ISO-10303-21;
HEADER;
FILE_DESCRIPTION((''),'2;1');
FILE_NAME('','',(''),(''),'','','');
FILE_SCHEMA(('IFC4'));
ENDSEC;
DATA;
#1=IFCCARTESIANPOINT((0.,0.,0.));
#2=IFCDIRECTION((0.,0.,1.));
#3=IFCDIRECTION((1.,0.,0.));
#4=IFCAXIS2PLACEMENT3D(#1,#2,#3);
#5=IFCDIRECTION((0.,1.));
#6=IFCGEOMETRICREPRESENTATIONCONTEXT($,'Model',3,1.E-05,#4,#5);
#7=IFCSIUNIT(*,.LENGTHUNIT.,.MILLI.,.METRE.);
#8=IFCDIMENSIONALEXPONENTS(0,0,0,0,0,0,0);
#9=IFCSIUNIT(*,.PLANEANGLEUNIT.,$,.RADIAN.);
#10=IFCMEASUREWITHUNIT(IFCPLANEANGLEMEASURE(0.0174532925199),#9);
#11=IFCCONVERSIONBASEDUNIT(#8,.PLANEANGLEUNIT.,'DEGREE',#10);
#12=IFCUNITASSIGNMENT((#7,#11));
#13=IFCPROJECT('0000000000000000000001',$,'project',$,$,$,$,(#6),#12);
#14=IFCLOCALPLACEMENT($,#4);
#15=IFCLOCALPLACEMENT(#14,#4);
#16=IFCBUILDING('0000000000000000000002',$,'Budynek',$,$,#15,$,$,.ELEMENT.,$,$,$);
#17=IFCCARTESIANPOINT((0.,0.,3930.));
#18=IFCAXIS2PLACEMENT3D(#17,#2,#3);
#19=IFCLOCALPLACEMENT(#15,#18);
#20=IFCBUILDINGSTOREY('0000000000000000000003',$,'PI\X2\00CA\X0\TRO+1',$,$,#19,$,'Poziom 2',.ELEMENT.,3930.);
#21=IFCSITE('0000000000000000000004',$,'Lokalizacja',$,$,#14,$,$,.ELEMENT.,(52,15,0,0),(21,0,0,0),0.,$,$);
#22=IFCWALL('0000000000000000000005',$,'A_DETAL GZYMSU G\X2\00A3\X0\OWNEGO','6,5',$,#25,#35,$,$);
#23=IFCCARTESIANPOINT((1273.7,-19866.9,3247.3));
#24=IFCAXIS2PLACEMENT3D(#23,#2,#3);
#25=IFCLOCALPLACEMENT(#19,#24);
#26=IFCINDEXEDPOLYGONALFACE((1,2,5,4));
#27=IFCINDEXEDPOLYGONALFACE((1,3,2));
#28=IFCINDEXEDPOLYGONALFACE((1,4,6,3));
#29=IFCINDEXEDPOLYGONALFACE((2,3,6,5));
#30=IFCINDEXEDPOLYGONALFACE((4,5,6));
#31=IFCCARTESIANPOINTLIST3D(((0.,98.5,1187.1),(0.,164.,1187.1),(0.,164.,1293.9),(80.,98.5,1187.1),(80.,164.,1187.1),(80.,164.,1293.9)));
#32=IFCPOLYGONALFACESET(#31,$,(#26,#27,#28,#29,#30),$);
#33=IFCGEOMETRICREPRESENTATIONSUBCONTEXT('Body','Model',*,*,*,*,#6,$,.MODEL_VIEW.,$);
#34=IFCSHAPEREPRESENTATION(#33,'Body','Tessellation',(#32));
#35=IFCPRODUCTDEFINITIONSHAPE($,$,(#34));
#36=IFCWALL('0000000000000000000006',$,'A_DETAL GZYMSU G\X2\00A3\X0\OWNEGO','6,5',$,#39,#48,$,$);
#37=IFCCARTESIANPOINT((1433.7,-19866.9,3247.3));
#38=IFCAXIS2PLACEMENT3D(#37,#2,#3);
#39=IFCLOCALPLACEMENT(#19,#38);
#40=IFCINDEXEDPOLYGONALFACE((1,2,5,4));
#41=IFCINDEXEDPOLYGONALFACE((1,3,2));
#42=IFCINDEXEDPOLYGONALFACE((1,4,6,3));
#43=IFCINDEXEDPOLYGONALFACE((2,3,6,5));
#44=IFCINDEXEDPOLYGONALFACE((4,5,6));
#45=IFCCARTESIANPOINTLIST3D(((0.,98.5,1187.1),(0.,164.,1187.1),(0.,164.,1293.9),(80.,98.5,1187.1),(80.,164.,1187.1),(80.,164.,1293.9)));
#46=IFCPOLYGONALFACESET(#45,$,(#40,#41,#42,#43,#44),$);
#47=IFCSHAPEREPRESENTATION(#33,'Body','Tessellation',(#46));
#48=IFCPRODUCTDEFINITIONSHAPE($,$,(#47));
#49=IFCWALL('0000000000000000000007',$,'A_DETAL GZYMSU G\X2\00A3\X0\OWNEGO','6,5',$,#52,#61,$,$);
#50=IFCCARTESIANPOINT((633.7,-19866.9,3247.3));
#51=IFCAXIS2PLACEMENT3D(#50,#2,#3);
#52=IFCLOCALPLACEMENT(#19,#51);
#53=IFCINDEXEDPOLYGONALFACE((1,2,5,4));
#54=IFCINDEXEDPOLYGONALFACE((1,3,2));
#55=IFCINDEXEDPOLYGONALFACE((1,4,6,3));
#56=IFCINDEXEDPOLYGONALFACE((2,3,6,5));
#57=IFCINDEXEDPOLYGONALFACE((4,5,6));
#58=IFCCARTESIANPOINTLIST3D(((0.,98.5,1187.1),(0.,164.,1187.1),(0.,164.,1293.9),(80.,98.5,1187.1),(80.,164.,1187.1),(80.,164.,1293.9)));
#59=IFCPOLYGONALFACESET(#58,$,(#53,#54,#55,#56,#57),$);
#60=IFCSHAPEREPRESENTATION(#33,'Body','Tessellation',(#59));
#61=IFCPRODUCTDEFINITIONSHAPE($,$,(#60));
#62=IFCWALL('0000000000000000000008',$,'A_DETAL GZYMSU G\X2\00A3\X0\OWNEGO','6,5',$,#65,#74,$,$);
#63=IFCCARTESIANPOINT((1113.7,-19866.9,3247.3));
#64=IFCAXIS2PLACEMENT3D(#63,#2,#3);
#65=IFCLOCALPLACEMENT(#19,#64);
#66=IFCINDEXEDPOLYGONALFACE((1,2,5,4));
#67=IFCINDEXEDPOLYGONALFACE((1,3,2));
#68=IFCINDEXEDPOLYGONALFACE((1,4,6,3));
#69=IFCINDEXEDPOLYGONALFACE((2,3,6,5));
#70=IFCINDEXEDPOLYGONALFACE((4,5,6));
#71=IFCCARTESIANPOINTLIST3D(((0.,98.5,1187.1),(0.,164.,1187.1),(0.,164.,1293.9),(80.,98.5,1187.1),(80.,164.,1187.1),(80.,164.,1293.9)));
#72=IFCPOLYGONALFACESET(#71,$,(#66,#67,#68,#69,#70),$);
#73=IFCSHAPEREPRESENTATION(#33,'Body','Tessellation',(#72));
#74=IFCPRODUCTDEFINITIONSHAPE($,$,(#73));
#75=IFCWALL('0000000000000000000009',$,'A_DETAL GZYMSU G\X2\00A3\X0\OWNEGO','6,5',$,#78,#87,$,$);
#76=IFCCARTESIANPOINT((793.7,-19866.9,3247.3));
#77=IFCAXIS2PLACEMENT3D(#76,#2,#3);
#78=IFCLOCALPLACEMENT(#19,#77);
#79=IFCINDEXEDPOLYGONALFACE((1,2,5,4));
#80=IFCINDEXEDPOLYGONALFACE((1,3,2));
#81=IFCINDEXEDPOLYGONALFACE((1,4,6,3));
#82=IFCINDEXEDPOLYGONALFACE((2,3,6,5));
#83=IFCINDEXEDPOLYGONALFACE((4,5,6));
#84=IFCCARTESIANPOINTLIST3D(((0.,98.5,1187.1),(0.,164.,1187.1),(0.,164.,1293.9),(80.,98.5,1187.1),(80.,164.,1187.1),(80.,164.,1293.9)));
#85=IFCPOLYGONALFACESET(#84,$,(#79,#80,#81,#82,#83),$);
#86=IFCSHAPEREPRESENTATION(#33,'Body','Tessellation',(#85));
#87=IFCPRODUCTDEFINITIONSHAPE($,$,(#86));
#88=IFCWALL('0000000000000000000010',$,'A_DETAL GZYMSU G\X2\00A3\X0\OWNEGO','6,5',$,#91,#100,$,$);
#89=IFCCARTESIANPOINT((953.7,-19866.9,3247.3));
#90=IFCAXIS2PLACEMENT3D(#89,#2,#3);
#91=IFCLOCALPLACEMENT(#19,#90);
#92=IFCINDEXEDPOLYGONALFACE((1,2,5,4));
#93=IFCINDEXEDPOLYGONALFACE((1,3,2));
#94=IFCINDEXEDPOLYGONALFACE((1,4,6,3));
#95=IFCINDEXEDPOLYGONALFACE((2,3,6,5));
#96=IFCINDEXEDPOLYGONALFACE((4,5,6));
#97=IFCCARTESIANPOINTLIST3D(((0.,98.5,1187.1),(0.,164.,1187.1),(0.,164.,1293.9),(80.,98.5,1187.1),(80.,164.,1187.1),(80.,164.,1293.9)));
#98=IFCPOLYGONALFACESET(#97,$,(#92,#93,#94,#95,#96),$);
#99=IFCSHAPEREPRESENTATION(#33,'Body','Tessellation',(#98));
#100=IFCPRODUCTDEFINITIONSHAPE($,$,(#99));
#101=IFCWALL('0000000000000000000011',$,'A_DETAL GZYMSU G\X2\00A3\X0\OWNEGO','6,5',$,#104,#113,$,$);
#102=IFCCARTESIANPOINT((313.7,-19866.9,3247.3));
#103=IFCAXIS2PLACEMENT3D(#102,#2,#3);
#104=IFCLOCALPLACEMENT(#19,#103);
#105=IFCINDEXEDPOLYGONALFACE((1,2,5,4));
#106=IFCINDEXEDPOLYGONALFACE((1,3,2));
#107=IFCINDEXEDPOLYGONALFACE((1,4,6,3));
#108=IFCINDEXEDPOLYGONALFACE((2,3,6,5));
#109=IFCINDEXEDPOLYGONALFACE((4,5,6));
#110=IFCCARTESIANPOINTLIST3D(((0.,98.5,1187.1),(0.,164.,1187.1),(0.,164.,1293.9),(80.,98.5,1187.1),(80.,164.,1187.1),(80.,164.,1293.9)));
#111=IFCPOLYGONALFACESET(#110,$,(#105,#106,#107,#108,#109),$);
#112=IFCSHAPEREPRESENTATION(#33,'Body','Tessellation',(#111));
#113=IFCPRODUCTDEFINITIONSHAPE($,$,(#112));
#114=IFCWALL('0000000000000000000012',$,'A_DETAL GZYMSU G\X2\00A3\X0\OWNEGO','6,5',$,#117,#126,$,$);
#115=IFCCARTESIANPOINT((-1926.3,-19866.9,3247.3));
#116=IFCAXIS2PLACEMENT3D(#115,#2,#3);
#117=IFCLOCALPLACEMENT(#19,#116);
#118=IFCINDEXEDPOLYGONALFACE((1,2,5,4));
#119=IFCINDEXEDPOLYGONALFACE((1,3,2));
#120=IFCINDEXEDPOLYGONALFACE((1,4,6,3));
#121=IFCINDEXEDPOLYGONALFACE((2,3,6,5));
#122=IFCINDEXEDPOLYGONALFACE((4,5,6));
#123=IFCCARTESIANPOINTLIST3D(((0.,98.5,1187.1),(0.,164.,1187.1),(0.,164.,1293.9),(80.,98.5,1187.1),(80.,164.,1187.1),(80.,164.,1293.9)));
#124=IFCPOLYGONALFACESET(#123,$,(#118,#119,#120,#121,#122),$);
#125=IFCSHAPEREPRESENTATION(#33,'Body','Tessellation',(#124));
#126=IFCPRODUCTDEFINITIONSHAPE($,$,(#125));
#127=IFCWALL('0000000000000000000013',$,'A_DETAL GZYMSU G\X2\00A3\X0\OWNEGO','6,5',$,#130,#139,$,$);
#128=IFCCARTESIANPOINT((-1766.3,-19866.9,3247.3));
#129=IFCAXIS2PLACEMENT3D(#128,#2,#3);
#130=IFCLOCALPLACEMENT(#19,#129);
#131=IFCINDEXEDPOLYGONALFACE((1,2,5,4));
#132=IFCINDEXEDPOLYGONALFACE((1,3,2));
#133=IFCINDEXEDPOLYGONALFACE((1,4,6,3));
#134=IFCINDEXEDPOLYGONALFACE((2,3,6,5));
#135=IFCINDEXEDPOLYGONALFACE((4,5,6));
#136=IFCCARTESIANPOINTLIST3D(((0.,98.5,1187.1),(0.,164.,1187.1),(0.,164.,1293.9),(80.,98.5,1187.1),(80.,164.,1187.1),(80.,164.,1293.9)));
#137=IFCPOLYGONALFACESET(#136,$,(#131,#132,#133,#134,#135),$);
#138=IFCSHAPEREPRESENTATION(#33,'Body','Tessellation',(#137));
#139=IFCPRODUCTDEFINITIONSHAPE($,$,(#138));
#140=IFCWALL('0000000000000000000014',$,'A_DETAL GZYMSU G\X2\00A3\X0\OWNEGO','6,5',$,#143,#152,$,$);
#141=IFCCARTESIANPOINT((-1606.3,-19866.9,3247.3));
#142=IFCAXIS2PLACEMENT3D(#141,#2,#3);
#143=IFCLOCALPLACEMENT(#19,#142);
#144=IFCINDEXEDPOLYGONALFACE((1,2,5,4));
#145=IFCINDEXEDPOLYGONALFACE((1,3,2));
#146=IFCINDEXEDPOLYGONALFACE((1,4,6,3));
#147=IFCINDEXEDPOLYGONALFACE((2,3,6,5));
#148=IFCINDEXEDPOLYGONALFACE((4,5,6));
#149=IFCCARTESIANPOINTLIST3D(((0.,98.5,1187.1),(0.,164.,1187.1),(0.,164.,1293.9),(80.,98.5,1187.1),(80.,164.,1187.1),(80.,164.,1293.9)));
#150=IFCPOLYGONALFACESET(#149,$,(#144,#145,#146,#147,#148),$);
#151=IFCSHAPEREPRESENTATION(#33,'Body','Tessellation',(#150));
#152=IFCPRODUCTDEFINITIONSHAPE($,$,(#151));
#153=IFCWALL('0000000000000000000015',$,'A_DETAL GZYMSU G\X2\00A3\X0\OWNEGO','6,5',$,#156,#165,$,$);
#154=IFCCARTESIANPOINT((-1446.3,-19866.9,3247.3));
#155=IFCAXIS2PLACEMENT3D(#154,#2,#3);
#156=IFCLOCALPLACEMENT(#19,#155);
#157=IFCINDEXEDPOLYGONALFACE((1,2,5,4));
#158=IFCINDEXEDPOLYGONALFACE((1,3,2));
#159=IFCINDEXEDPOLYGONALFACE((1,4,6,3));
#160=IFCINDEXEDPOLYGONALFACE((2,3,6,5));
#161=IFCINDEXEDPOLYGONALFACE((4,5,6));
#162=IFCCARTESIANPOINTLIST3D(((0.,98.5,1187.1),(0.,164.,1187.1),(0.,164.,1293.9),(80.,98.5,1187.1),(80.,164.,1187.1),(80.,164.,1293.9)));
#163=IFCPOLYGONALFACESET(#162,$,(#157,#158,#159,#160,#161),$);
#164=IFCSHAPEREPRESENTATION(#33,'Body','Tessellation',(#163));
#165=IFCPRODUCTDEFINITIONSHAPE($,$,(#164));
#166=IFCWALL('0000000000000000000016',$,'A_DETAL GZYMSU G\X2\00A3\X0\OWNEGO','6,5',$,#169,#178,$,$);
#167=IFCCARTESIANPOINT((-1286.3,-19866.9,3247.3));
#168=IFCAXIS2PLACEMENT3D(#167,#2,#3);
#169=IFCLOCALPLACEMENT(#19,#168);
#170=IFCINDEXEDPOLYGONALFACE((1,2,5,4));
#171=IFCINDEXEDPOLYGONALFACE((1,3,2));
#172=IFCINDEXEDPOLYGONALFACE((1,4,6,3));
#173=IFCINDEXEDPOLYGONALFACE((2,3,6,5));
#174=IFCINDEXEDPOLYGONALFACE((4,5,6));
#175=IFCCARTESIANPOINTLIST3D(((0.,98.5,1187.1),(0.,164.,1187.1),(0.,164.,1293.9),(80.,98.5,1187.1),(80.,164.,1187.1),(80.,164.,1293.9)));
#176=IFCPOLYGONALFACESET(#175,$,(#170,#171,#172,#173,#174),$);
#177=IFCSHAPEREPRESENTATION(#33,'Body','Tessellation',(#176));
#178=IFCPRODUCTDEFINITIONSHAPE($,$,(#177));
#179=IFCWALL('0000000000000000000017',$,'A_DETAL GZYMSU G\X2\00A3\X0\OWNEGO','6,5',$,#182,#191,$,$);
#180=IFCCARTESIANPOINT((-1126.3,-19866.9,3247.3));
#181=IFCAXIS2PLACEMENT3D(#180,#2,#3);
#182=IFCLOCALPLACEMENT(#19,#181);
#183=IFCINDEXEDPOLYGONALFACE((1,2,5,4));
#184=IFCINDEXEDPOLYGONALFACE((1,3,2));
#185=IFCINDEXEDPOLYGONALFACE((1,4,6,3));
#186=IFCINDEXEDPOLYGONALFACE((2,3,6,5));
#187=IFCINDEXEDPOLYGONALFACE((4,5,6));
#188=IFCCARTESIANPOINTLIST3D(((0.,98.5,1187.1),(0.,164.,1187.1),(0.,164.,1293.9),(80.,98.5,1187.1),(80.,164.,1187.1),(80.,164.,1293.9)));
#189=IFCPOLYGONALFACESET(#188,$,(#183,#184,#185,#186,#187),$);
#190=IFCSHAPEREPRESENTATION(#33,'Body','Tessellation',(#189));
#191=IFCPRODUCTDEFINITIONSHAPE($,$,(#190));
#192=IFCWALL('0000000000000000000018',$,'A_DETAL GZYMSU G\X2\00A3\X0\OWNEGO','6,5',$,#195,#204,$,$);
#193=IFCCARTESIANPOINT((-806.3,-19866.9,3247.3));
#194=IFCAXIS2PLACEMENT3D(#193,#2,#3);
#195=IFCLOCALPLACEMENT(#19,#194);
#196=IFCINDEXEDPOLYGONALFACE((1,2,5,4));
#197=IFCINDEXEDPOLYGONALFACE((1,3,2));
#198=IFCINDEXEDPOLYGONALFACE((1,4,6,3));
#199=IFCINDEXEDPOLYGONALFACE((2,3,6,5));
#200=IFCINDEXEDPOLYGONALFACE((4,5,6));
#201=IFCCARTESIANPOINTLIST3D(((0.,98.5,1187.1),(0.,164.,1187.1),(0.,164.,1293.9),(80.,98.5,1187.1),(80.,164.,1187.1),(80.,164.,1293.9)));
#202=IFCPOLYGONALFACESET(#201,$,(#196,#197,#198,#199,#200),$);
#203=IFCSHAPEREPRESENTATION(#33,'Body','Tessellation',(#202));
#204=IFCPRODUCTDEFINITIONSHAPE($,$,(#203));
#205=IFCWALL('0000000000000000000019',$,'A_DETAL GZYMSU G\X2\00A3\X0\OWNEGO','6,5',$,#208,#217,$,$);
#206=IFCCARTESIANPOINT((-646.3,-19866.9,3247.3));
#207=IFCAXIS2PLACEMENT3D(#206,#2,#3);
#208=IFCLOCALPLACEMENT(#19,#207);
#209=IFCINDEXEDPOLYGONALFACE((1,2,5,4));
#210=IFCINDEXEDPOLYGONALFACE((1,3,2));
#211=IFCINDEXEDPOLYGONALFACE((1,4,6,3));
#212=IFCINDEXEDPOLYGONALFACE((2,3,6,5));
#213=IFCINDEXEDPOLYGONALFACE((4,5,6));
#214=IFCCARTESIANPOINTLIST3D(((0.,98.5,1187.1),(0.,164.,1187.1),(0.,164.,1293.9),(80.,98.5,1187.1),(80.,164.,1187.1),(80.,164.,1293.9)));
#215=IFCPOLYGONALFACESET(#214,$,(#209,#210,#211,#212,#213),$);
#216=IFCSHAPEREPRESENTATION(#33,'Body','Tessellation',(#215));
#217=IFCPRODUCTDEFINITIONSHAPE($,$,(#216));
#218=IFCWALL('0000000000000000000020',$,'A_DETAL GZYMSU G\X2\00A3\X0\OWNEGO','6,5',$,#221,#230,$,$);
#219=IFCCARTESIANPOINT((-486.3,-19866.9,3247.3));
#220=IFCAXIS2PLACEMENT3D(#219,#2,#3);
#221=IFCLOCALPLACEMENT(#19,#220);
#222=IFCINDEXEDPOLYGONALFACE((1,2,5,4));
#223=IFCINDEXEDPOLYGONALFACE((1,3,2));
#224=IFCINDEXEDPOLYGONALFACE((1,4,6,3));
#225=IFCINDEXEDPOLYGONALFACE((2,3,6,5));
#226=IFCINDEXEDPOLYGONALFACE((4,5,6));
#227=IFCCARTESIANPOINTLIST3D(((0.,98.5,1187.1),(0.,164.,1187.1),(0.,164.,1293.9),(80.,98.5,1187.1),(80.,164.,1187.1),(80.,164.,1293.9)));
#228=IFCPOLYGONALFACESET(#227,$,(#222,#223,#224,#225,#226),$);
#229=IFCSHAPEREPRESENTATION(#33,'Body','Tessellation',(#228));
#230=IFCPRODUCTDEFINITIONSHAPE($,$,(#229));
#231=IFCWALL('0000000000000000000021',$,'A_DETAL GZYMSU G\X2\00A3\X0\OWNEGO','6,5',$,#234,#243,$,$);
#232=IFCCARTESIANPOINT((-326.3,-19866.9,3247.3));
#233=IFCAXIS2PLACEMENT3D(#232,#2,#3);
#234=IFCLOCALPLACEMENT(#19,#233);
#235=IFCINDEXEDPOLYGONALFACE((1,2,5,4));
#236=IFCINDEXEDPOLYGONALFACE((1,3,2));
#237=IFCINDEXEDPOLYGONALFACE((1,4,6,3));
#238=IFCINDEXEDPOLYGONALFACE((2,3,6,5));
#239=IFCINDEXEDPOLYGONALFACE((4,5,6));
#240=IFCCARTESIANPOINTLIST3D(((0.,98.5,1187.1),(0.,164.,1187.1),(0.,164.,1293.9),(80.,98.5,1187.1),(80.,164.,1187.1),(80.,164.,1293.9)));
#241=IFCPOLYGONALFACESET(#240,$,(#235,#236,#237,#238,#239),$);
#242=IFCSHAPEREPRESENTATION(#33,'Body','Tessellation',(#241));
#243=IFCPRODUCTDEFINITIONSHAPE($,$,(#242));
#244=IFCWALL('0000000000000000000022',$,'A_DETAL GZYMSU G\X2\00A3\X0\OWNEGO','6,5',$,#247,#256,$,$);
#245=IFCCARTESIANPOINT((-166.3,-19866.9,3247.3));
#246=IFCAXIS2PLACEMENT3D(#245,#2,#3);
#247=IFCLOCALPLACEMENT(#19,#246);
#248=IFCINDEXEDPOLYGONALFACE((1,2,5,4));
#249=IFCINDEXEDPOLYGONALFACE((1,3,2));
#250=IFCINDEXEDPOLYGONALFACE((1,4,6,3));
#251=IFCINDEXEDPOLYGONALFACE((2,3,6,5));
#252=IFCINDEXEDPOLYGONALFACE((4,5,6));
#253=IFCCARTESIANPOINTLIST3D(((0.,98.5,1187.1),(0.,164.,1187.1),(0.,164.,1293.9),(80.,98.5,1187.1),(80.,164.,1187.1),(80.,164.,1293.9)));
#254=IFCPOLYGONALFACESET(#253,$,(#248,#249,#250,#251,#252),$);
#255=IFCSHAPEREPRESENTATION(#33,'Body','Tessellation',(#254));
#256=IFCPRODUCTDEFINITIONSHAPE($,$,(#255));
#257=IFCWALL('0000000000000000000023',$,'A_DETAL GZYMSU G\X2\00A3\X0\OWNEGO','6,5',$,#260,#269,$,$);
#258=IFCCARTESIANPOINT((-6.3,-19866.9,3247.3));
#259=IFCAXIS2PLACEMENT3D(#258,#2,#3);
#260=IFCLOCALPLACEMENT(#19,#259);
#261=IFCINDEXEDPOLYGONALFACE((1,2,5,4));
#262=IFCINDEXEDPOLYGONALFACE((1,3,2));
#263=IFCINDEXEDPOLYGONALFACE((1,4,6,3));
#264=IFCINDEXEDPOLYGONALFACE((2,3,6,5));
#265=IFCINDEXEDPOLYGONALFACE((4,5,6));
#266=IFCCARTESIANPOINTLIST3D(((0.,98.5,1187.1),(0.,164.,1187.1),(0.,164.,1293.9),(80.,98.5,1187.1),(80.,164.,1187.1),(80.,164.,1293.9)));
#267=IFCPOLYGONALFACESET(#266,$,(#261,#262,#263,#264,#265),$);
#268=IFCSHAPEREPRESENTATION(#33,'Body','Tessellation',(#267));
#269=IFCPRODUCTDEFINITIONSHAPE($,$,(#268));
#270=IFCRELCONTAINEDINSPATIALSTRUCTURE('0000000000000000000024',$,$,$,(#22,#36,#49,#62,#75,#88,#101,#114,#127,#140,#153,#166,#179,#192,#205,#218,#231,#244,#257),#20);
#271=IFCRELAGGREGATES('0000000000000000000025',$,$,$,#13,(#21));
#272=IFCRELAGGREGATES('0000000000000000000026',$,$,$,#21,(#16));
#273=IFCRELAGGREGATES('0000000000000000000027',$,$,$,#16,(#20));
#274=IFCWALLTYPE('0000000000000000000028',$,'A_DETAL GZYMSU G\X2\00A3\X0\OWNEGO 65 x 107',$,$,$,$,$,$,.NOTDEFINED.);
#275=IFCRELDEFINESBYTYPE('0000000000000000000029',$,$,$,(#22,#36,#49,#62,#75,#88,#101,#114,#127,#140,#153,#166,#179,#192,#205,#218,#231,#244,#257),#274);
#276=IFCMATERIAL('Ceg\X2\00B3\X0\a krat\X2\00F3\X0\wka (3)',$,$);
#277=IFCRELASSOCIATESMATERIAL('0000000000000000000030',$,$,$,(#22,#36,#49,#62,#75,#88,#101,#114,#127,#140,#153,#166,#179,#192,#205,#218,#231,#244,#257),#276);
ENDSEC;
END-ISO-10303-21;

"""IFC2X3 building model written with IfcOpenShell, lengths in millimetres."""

from ifc_helpers import new_model, entity, si_unit, converted_unit, direction, frame, origin_with_axes, place, context, subcontext, project, spatial, polyline, outline, extrude, material, type_object, element, save


model = new_model("IFC2X3")

# Units and contexts
model_context = context("Model", 3, precision=1e-05, world=origin_with_axes(), true_north=direction((0.0, 1.0)))
body_context = subcontext(model_context, "Body", "Model", "MODEL_VIEW")
ifc_project = project(units=[si_unit("LENGTHUNIT", "METRE", prefix="MILLI"), converted_unit("PLANEANGLEUNIT", "DEGREE", entity("IfcPlaneAngleMeasure", 0.0174532925199), si_unit("PLANEANGLEUNIT", "RADIAN"), dimensions=[0, 0, 0, 0, 0, 0, 0])], contexts=[model_context])

# Site, building, storey
site_placement = place(None, origin_with_axes())
site = spatial("IfcSite", under=ifc_project, at=site_placement, Name="Lokalizacja", CompositionType="ELEMENT", RefLatitude=(52, 15, 0, 0), RefLongitude=(21, 0, 0, 0), RefElevation=0.0)
building_placement = place(site_placement, origin_with_axes())
building = spatial("IfcBuilding", under=site, at=building_placement, Name="Budynek", CompositionType="ELEMENT")
storey_placement = place(building_placement, frame((0.0, 0.0, 3930.0), z_axis=(0.0, 0.0, 1.0), x_axis=(1.0, 0.0, 0.0)))
storey = spatial("IfcBuildingStorey", under=building, at=storey_placement, Name="PIÊTRO+1", LongName="Poziom 2", CompositionType="ELEMENT", Elevation=3930.0)

# Walls
ifc_material = material(Name="Ceg³a kratówka (3)")
wall_type = type_object("IfcWallType", Name="A_DETAL GZYMSU G£OWNEGO 65 x 107", PredefinedType="NOTDEFINED")
for number, where, z_axis, x_axis, name in (
    (1, (1273.7, -19866.9, 3247.3), (0.0, 0.0, 1.0), (1.0, 0.0, 0.0), "A_DETAL GZYMSU G£OWNEGO"),
    (2, (1433.7, -19866.9, 3247.3), (0.0, 0.0, 1.0), (1.0, 0.0, 0.0), "A_DETAL GZYMSU G£OWNEGO"),
    (3, (633.7, -19866.9, 3247.3), (0.0, 0.0, 1.0), (1.0, 0.0, 0.0), "A_DETAL GZYMSU G£OWNEGO"),
    (4, (1113.7, -19866.9, 3247.3), (0.0, 0.0, 1.0), (1.0, 0.0, 0.0), "A_DETAL GZYMSU G£OWNEGO"),
    (5, (793.7, -19866.9, 3247.3), (0.0, 0.0, 1.0), (1.0, 0.0, 0.0), "A_DETAL GZYMSU G£OWNEGO"),
    (6, (953.7, -19866.9, 3247.3), (0.0, 0.0, 1.0), (1.0, 0.0, 0.0), "A_DETAL GZYMSU G£OWNEGO"),
    (7, (313.7, -19866.9, 3247.3), (0.0, 0.0, 1.0), (1.0, 0.0, 0.0), "A_DETAL GZYMSU G£OWNEGO"),
    (8, (-1926.3, -19866.9, 3247.3), (0.0, 0.0, 1.0), (1.0, 0.0, 0.0), "A_DETAL GZYMSU G£OWNEGO"),
    (9, (-1766.3, -19866.9, 3247.3), (0.0, 0.0, 1.0), (1.0, 0.0, 0.0), "A_DETAL GZYMSU G£OWNEGO"),
    (10, (-1606.3, -19866.9, 3247.3), (0.0, 0.0, 1.0), (1.0, 0.0, 0.0), "A_DETAL GZYMSU G£OWNEGO"),
    (11, (-1446.3, -19866.9, 3247.3), (0.0, 0.0, 1.0), (1.0, 0.0, 0.0), "A_DETAL GZYMSU G£OWNEGO"),
    (12, (-1286.3, -19866.9, 3247.3), (0.0, 0.0, 1.0), (1.0, 0.0, 0.0), "A_DETAL GZYMSU G£OWNEGO"),
    (13, (-1126.3, -19866.9, 3247.3), (0.0, 0.0, 1.0), (1.0, 0.0, 0.0), "A_DETAL GZYMSU G£OWNEGO"),
    (14, (-806.3, -19866.9, 3247.3), (0.0, 0.0, 1.0), (1.0, 0.0, 0.0), "A_DETAL GZYMSU G£OWNEGO"),
    (15, (-646.3, -19866.9, 3247.3), (0.0, 0.0, 1.0), (1.0, 0.0, 0.0), "A_DETAL GZYMSU G£OWNEGO"),
    (16, (-486.3, -19866.9, 3247.3), (0.0, 0.0, 1.0), (1.0, 0.0, 0.0), "A_DETAL GZYMSU G£OWNEGO"),
    (17, (-326.3, -19866.9, 3247.3), (0.0, 0.0, 1.0), (1.0, 0.0, 0.0), "A_DETAL GZYMSU G£OWNEGO"),
    (18, (-166.3, -19866.9, 3247.3), (0.0, 0.0, 1.0), (1.0, 0.0, 0.0), "A_DETAL GZYMSU G£OWNEGO"),
    (19, (-6.3, -19866.9, 3247.3), (0.0, 0.0, 1.0), (1.0, 0.0, 0.0), "A_DETAL GZYMSU G£OWNEGO"),
):
    element("IfcWall", number, at=place(storey_placement, frame(where, z_axis=z_axis, x_axis=x_axis)), inside=storey, type_object=wall_type, material=ifc_material, Name=name, Description="6,5", context=body_context, shape_type="SweptSolid", body=[
        extrude(outline(polyline([(-164.0, 1293.9), (-164.0, 1187.1), (-98.5, 1187.1), (-164.0, 1293.9)])), frame((0.0, 0.0, 0.0), z_axis=(-1.0, 0.0, 0.0), x_axis=(0.0, -1.0, 0.0)), (0.0, 0.0, -1.0), 80.0),
    ])

save(model, "model.ifc")
